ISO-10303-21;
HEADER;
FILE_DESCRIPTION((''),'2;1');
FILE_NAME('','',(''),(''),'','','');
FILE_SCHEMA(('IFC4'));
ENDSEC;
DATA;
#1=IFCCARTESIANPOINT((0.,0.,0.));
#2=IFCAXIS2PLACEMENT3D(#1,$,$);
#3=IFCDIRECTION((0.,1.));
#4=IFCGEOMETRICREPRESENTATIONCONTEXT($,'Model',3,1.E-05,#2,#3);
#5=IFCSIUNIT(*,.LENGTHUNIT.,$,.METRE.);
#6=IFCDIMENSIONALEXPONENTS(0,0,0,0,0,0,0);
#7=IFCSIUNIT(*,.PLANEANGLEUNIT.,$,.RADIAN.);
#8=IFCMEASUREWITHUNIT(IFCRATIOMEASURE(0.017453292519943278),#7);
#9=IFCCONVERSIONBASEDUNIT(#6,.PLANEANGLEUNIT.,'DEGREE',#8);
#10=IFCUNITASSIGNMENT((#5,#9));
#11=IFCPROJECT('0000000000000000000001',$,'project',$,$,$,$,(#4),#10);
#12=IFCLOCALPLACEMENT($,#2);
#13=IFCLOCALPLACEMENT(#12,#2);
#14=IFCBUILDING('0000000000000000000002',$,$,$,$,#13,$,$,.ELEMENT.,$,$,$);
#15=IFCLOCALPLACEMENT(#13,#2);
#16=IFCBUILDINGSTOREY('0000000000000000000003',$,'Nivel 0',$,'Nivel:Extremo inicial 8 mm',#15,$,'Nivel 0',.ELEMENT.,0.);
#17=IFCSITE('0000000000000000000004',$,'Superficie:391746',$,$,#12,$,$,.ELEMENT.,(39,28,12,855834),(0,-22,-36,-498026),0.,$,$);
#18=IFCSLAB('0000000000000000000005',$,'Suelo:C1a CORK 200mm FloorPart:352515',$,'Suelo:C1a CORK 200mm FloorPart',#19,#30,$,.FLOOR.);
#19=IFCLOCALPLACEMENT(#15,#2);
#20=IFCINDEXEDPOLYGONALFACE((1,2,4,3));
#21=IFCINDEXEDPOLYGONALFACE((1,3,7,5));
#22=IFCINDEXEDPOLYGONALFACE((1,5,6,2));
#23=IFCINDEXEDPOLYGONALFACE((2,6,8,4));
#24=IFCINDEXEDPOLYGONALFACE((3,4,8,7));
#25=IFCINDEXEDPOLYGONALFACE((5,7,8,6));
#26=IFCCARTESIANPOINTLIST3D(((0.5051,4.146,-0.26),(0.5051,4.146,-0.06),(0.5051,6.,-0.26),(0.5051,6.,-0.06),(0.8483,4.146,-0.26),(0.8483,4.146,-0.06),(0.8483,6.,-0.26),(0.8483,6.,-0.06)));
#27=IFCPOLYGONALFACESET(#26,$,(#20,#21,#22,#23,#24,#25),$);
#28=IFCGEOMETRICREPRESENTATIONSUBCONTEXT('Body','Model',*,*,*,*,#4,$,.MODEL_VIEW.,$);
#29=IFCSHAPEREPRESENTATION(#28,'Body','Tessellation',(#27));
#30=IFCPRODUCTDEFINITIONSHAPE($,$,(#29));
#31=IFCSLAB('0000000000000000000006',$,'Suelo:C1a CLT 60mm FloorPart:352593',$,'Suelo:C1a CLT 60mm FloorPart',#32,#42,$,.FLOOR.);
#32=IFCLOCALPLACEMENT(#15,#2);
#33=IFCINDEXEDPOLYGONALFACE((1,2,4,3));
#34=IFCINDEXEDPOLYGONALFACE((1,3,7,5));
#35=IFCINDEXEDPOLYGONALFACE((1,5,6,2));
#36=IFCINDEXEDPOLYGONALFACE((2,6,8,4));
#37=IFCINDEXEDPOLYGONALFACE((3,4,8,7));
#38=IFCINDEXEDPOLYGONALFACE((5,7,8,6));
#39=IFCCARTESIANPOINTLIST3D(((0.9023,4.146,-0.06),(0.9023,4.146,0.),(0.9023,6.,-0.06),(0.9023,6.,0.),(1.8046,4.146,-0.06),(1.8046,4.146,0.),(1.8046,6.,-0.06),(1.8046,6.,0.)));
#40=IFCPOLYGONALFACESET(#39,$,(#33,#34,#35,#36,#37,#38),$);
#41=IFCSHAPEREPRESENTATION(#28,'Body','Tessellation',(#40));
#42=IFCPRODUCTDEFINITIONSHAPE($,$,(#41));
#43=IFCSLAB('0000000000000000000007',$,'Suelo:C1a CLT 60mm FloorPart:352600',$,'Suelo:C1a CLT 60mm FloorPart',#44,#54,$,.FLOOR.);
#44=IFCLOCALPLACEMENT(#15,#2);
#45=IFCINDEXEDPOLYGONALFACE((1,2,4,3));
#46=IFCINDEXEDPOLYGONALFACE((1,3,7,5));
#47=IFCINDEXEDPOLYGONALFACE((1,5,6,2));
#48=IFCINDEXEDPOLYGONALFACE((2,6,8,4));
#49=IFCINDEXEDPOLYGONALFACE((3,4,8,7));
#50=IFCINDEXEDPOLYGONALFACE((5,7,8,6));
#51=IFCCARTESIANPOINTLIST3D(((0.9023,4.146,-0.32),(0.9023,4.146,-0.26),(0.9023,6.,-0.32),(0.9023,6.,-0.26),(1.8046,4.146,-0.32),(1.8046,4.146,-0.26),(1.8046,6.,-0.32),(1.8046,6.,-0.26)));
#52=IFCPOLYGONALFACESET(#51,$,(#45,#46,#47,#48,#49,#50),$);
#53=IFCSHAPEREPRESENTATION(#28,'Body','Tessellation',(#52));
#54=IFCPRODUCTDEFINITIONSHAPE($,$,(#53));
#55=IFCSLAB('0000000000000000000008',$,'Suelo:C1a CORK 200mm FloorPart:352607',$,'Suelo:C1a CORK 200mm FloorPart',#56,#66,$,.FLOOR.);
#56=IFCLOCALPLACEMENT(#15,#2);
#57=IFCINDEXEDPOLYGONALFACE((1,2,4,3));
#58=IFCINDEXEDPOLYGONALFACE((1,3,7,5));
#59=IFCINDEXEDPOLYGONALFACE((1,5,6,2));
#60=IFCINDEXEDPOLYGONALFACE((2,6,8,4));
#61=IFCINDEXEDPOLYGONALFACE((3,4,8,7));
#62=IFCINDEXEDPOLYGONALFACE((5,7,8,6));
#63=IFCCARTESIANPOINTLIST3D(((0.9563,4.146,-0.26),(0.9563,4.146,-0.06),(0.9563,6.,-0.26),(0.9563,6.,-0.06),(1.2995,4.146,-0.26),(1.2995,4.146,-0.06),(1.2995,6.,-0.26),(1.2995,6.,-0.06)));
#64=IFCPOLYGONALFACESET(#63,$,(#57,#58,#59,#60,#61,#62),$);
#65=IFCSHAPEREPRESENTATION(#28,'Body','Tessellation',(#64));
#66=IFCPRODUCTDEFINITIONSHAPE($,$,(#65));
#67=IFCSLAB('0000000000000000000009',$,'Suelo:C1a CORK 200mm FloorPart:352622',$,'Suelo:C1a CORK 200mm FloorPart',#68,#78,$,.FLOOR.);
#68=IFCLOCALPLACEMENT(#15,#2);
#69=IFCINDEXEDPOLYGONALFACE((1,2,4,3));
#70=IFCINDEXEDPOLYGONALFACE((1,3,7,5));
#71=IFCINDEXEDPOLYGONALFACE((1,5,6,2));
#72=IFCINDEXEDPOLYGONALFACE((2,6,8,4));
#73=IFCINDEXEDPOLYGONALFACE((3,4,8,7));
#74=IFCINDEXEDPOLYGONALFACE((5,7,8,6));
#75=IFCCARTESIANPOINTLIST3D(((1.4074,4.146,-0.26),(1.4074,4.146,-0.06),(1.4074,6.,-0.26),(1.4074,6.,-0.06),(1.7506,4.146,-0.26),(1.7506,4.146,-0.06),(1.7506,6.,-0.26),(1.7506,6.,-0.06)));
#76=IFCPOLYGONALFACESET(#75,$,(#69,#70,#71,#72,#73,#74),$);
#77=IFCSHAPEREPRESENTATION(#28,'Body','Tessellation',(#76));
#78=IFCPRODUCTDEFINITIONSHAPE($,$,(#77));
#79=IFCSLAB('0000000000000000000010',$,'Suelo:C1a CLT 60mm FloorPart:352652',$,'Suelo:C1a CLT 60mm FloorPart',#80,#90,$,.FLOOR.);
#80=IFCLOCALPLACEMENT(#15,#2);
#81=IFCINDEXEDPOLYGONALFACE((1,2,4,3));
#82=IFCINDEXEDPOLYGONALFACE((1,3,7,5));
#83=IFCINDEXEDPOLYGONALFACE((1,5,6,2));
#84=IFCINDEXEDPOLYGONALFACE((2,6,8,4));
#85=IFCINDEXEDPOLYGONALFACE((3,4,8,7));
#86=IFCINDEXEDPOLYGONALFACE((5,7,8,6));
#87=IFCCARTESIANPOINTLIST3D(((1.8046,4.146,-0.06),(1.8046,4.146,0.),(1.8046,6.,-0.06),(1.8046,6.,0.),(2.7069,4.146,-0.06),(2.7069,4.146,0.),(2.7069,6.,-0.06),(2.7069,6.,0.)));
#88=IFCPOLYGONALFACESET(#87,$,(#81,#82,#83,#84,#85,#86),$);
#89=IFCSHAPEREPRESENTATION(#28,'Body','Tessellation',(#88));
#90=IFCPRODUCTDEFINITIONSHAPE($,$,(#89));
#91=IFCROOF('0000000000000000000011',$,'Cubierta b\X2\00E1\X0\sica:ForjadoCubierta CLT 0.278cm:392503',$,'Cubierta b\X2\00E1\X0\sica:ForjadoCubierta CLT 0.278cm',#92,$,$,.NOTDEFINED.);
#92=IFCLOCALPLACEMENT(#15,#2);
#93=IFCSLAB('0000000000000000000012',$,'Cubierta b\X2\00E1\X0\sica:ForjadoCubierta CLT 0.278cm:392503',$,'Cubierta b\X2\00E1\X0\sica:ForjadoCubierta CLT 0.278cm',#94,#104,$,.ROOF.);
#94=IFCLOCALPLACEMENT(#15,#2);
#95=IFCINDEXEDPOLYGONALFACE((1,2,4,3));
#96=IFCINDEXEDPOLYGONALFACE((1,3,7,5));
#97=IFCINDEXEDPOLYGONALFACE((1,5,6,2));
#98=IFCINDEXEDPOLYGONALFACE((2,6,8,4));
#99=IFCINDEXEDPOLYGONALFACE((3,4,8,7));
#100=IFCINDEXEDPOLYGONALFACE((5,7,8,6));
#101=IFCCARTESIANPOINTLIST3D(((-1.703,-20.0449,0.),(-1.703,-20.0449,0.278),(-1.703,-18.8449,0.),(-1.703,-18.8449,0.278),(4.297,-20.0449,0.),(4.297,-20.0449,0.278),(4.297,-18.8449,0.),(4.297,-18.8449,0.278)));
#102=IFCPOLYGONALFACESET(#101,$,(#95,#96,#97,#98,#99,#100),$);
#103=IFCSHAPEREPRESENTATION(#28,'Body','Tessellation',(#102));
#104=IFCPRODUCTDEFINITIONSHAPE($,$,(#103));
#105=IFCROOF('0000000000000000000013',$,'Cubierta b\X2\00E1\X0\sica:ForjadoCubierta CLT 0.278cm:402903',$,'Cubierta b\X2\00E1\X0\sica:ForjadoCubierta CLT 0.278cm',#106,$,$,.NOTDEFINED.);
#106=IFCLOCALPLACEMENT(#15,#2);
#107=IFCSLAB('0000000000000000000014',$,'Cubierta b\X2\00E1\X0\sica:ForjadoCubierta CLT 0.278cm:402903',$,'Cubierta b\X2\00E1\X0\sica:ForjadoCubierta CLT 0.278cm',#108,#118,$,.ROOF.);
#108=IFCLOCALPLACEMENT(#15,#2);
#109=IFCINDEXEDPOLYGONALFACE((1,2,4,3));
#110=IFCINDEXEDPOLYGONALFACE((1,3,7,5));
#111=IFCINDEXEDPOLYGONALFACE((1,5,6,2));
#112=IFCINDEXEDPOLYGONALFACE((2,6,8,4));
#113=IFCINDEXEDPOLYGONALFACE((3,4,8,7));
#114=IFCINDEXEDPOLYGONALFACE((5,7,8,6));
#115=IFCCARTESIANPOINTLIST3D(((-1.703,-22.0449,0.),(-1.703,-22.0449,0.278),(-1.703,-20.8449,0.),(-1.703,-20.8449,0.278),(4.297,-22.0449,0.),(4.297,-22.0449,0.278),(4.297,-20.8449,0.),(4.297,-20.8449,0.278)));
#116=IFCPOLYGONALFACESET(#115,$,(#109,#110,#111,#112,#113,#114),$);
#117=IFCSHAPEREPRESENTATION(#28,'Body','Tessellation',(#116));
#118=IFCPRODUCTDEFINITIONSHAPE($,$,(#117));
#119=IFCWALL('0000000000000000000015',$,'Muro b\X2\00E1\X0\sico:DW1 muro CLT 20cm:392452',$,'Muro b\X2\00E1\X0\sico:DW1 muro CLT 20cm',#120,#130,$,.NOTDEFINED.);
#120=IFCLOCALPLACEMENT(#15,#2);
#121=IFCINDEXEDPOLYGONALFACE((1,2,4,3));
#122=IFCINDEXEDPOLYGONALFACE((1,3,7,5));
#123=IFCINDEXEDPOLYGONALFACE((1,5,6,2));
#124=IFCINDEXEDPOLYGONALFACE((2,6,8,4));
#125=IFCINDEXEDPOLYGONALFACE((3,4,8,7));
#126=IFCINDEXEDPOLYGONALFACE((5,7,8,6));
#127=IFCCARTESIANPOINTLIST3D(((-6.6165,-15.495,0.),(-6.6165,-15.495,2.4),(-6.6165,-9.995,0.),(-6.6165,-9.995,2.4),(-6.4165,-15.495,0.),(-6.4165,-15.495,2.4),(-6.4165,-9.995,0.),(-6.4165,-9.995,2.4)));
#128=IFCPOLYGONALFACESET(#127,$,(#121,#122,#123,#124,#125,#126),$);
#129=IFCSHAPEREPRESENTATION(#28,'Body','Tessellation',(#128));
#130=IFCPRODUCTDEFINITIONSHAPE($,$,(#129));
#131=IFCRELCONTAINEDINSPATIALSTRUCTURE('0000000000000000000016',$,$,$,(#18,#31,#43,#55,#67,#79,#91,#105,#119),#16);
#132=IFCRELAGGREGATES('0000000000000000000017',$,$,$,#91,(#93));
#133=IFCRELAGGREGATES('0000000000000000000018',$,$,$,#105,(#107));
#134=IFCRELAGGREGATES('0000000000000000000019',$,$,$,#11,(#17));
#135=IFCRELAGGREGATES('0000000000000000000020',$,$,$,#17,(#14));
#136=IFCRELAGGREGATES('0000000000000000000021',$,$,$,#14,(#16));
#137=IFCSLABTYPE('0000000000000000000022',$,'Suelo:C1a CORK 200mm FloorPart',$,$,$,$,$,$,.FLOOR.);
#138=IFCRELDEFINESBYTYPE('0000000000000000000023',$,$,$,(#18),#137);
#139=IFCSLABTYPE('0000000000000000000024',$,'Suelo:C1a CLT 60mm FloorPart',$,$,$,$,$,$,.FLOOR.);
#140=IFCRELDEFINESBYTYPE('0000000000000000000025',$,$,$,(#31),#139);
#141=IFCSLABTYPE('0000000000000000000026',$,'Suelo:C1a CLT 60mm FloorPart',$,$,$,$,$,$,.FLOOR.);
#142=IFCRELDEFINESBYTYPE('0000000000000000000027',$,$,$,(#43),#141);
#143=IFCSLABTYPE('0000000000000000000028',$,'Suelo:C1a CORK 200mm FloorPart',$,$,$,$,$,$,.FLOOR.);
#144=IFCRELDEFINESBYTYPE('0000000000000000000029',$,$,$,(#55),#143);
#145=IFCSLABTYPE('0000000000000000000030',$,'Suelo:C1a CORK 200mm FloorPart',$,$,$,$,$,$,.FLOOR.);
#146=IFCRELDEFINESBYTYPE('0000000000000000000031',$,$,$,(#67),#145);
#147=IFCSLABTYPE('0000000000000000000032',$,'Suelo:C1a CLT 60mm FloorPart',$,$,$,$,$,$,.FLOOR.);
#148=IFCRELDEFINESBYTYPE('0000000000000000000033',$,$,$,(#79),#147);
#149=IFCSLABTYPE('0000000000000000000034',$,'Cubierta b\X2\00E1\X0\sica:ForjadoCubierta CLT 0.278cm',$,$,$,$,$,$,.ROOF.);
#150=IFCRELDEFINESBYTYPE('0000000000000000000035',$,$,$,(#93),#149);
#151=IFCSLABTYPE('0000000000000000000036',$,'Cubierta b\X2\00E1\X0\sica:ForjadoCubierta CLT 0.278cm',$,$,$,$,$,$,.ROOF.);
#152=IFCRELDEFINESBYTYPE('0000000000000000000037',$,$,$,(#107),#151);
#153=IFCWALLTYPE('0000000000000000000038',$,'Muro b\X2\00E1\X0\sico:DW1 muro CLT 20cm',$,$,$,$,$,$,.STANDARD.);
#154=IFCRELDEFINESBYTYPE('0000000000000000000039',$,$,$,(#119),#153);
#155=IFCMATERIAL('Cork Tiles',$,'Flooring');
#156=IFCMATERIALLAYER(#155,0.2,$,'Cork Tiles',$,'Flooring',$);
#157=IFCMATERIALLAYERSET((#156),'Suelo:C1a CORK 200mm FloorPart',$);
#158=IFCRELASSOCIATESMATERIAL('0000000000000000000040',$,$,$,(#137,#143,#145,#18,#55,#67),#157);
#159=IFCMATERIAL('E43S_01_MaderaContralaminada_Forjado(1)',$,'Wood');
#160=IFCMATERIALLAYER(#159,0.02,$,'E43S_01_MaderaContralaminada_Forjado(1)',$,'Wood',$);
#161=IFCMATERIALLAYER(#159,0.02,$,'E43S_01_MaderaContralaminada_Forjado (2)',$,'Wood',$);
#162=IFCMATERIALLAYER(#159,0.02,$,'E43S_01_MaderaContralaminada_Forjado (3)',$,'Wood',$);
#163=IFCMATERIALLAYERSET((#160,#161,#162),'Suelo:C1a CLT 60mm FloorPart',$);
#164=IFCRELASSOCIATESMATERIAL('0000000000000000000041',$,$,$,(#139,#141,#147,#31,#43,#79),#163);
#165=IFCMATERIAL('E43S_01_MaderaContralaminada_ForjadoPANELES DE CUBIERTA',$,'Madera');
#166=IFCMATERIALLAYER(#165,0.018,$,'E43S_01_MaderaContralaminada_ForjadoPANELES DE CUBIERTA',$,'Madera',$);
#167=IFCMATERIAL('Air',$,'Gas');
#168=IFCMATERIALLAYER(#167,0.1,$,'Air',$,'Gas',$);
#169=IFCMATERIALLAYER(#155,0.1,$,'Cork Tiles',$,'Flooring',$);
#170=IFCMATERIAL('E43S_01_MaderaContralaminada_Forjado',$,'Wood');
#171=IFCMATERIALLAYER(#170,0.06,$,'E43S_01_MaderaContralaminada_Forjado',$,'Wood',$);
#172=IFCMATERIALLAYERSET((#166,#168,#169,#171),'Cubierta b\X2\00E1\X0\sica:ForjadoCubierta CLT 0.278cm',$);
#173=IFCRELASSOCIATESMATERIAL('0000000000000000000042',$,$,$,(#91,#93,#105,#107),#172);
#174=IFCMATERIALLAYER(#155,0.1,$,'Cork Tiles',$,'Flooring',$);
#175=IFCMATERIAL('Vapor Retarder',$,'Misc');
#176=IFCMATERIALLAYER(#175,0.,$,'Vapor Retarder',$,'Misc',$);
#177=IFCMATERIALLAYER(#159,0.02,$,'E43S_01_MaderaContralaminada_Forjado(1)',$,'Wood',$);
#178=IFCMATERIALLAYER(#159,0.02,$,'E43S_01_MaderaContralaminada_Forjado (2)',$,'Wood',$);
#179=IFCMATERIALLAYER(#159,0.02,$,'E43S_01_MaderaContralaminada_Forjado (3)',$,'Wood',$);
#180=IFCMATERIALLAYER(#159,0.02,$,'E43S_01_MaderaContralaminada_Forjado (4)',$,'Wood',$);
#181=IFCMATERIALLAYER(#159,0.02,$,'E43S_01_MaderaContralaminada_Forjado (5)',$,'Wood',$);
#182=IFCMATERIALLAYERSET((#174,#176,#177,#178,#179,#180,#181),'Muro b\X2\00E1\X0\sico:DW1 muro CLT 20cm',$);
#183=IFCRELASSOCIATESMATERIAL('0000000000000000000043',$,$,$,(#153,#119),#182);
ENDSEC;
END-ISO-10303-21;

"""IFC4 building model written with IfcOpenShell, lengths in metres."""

from ifc_helpers import new_model, entity, si_unit, converted_unit, direction, frame, frame_2d, origin, origin_2d_with_axis, place, context, subcontext, project, spatial, rectangle, extrude, material, layer, layer_set, layer_usage, type_object, element, aggregate, save


model = new_model("IFC4")

# Units and contexts
model_context = context("Model", 3, precision=1e-05, world=origin(), true_north=direction((0.0, 1.0)))
body_context = subcontext(model_context, "Body", "Model", "MODEL_VIEW")
ifc_project = project(units=[si_unit("LENGTHUNIT", "METRE"), converted_unit("PLANEANGLEUNIT", "DEGREE", entity("IfcRatioMeasure", 0.017453292519943278), si_unit("PLANEANGLEUNIT", "RADIAN"), dimensions=[0, 0, 0, 0, 0, 0, 0])], contexts=[model_context])

# Site, building, storey
site_placement = place(None, origin())
site = spatial("IfcSite", under=ifc_project, at=site_placement, Name="Superficie:391746", CompositionType="ELEMENT", RefLatitude=(39, 28, 12, 855834), RefLongitude=(0, -22, -36, -498026), RefElevation=0.0)
building_placement = place(site_placement, origin())
building = spatial("IfcBuilding", under=site, at=building_placement, CompositionType="ELEMENT")
storey_placement = place(building_placement, origin())
storey = spatial("IfcBuildingStorey", under=building, at=storey_placement, Name="Nivel 0", ObjectType="Nivel:Extremo inicial 8 mm", LongName="Nivel 0", CompositionType="ELEMENT", Elevation=0.0)

# Shared definitions
ifc_material_1 = material(Name="E43S_01_MaderaContralaminada_Forjado(1)", Category="Wood")

# Slabs
ifc_layer_1 = layer(ifc_material_1, 0.02, Name="E43S_01_MaderaContralaminada_Forjado(1)", Category="Wood")
ifc_layer_2 = layer(ifc_material_1, 0.02, Name="E43S_01_MaderaContralaminada_Forjado (2)", Category="Wood")
ifc_layer_3 = layer(ifc_material_1, 0.02, Name="E43S_01_MaderaContralaminada_Forjado (3)", Category="Wood")
ifc_layer_set_1 = layer_set([ifc_layer_1, ifc_layer_2, ifc_layer_3], Name="Suelo:C1a CLT 60mm FloorPart")
ifc_material_2 = material(Name="Cork Tiles", Category="Flooring")
ifc_layer_4 = layer(ifc_material_2, 0.2, Name="Cork Tiles", Category="Flooring")
ifc_layer_set_2 = layer_set([ifc_layer_4], Name="Suelo:C1a CORK 200mm FloorPart")
ifc_layer_usage_1 = layer_usage(ifc_layer_set_2, "AXIS3", "POSITIVE", 0.0)
slab_type_1 = type_object("IfcSlabType", Name="Suelo:C1a CORK 200mm FloorPart", PredefinedType="FLOOR", material=ifc_layer_set_2)
slab_1_placement = place(storey_placement, origin())
element("IfcSlab", 1, at=slab_1_placement, inside=storey, type_object=slab_type_1, material=ifc_layer_usage_1, Name="Suelo:C1a CORK 200mm FloorPart:352515", ObjectType="Suelo:C1a CORK 200mm FloorPart", PredefinedType="FLOOR", context=body_context, shape_type="SweptSolid", body=[
    extrude(rectangle(XDim=1.854, YDim=0.3432, at=frame_2d((0.0, 0.0), x_axis=(1.0, 0.0))), frame((0.6767, 5.073, -0.06), z_axis=(0.0, 0.0, -1.0), x_axis=(0.0, 1.0, 0.0)), (0.0, 0.0, 1.0), 0.2),
])
ifc_layer_usage_2 = layer_usage(ifc_layer_set_1, "AXIS3", "POSITIVE", 0.0)
slab_type_2 = type_object("IfcSlabType", Name="Suelo:C1a CLT 60mm FloorPart", PredefinedType="FLOOR", material=ifc_layer_set_1)
slab_2_placement = place(storey_placement, origin())
element("IfcSlab", 2, at=slab_2_placement, inside=storey, type_object=slab_type_2, material=ifc_layer_usage_2, Name="Suelo:C1a CLT 60mm FloorPart:352593", ObjectType="Suelo:C1a CLT 60mm FloorPart", PredefinedType="FLOOR", context=body_context, shape_type="SweptSolid", body=[
    extrude(rectangle(XDim=1.854, YDim=0.9023, at=frame_2d((0.0, 0.0), x_axis=(1.0, 0.0))), frame((1.3535, 5.073, 0.0), z_axis=(0.0, 0.0, -1.0), x_axis=(0.0, 1.0, 0.0)), (0.0, 0.0, 1.0), 0.06),
])
ifc_layer_usage_3 = layer_usage(ifc_layer_set_1, "AXIS3", "POSITIVE", 0.0)
slab_type_3 = type_object("IfcSlabType", Name="Suelo:C1a CLT 60mm FloorPart", PredefinedType="FLOOR", material=ifc_layer_set_1)
slab_3_placement = place(storey_placement, origin())
element("IfcSlab", 3, at=slab_3_placement, inside=storey, type_object=slab_type_3, material=ifc_layer_usage_3, Name="Suelo:C1a CLT 60mm FloorPart:352600", ObjectType="Suelo:C1a CLT 60mm FloorPart", PredefinedType="FLOOR", context=body_context, shape_type="SweptSolid", body=[
    extrude(rectangle(XDim=1.854, YDim=0.9023, at=frame_2d((0.0, 0.0), x_axis=(1.0, 0.0))), frame((1.3535, 5.073, -0.26), z_axis=(0.0, 0.0, -1.0), x_axis=(0.0, 1.0, 0.0)), (0.0, 0.0, 1.0), 0.06),
])
ifc_layer_usage_4 = layer_usage(ifc_layer_set_2, "AXIS3", "POSITIVE", 0.0)
slab_type_4 = type_object("IfcSlabType", Name="Suelo:C1a CORK 200mm FloorPart", PredefinedType="FLOOR", material=ifc_layer_set_2)
slab_4_placement = place(storey_placement, origin())
element("IfcSlab", 4, at=slab_4_placement, inside=storey, type_object=slab_type_4, material=ifc_layer_usage_4, Name="Suelo:C1a CORK 200mm FloorPart:352607", ObjectType="Suelo:C1a CORK 200mm FloorPart", PredefinedType="FLOOR", context=body_context, shape_type="SweptSolid", body=[
    extrude(rectangle(XDim=1.854, YDim=0.3432, at=frame_2d((0.0, 0.0), x_axis=(1.0, 0.0))), frame((1.1279, 5.073, -0.06), z_axis=(0.0, 0.0, -1.0), x_axis=(0.0, 1.0, 0.0)), (0.0, 0.0, 1.0), 0.2),
])
ifc_layer_usage_5 = layer_usage(ifc_layer_set_2, "AXIS3", "POSITIVE", 0.0)
slab_type_5 = type_object("IfcSlabType", Name="Suelo:C1a CORK 200mm FloorPart", PredefinedType="FLOOR", material=ifc_layer_set_2)
slab_5_placement = place(storey_placement, origin())
element("IfcSlab", 5, at=slab_5_placement, inside=storey, type_object=slab_type_5, material=ifc_layer_usage_5, Name="Suelo:C1a CORK 200mm FloorPart:352622", ObjectType="Suelo:C1a CORK 200mm FloorPart", PredefinedType="FLOOR", context=body_context, shape_type="SweptSolid", body=[
    extrude(rectangle(XDim=1.854, YDim=0.3432, at=frame_2d((0.0, 0.0), x_axis=(1.0, 0.0))), frame((1.579, 5.073, -0.06), z_axis=(0.0, 0.0, -1.0), x_axis=(0.0, 1.0, 0.0)), (0.0, 0.0, 1.0), 0.2),
])
ifc_layer_usage_6 = layer_usage(ifc_layer_set_1, "AXIS3", "POSITIVE", 0.0)
slab_type_6 = type_object("IfcSlabType", Name="Suelo:C1a CLT 60mm FloorPart", PredefinedType="FLOOR", material=ifc_layer_set_1)
slab_6_placement = place(storey_placement, origin())
element("IfcSlab", 6, at=slab_6_placement, inside=storey, type_object=slab_type_6, material=ifc_layer_usage_6, Name="Suelo:C1a CLT 60mm FloorPart:352652", ObjectType="Suelo:C1a CLT 60mm FloorPart", PredefinedType="FLOOR", context=body_context, shape_type="SweptSolid", body=[
    extrude(rectangle(XDim=1.854, YDim=0.9023, at=frame_2d((0.0, 0.0), x_axis=(1.0, 0.0))), frame((2.2558, 5.073, 0.0), z_axis=(0.0, 0.0, -1.0), x_axis=(0.0, 1.0, 0.0)), (0.0, 0.0, 1.0), 0.06),
])

# Roofs, slabs
ifc_material_3 = material(Name="E43S_01_MaderaContralaminada_ForjadoPANELES DE CUBIERTA", Category="Madera")
ifc_layer_5 = layer(ifc_material_3, 0.018, Name="E43S_01_MaderaContralaminada_ForjadoPANELES DE CUBIERTA", Category="Madera")
ifc_material_4 = material(Name="Air", Category="Gas")
ifc_layer_6 = layer(ifc_material_4, 0.1, Name="Air", Category="Gas")
ifc_layer_7 = layer(ifc_material_2, 0.1, Name="Cork Tiles", Category="Flooring")
ifc_material_5 = material(Name="E43S_01_MaderaContralaminada_Forjado", Category="Wood")
ifc_layer_8 = layer(ifc_material_5, 0.06, Name="E43S_01_MaderaContralaminada_Forjado", Category="Wood")
ifc_layer_set_3 = layer_set([ifc_layer_5, ifc_layer_6, ifc_layer_7, ifc_layer_8], Name="Cubierta básica:ForjadoCubierta CLT 0.278cm")
roof_1_placement = place(storey_placement, frame((-1.703, -20.0449, 0.0)))
roof_1 = element("IfcRoof", 7, at=roof_1_placement, inside=storey, material=ifc_layer_set_3, Name="Cubierta básica:ForjadoCubierta CLT 0.278cm:392503", ObjectType="Cubierta básica:ForjadoCubierta CLT 0.278cm", PredefinedType="NOTDEFINED")
slab_type_7 = type_object("IfcSlabType", Name="Cubierta básica:ForjadoCubierta CLT 0.278cm", PredefinedType="ROOF")
slab_7_placement = place(roof_1_placement, origin())
slab_7 = element("IfcSlab", 8, at=slab_7_placement, type_object=slab_type_7, material=ifc_layer_set_3, Name="Cubierta básica:ForjadoCubierta CLT 0.278cm:392503", ObjectType="Cubierta básica:ForjadoCubierta CLT 0.278cm", PredefinedType="ROOF", context=body_context, shape_type="SweptSolid", body=[
    extrude(rectangle(XDim=6.0, YDim=1.2, at=frame_2d((0.0, 0.0), x_axis=(1.0, 0.0))), frame((3.0, 0.6, 0.0)), (0.0, 0.0, 1.0), 0.278),
])
aggregate(roof_1, [slab_7])
roof_2_placement = place(storey_placement, frame((-1.703, -22.0449, 0.0)))
roof_2 = element("IfcRoof", 9, at=roof_2_placement, inside=storey, material=ifc_layer_set_3, Name="Cubierta básica:ForjadoCubierta CLT 0.278cm:402903", ObjectType="Cubierta básica:ForjadoCubierta CLT 0.278cm", PredefinedType="NOTDEFINED")
slab_type_8 = type_object("IfcSlabType", Name="Cubierta básica:ForjadoCubierta CLT 0.278cm", PredefinedType="ROOF")
slab_8_placement = place(roof_2_placement, origin())
slab_8 = element("IfcSlab", 10, at=slab_8_placement, type_object=slab_type_8, material=ifc_layer_set_3, Name="Cubierta básica:ForjadoCubierta CLT 0.278cm:402903", ObjectType="Cubierta básica:ForjadoCubierta CLT 0.278cm", PredefinedType="ROOF", context=body_context, shape_type="SweptSolid", body=[
    extrude(rectangle(XDim=6.0, YDim=1.2, at=origin_2d_with_axis()), frame((3.0, 0.6, 0.0)), (0.0, 0.0, 1.0), 0.278),
])
aggregate(roof_2, [slab_8])

# Wall
ifc_layer_9 = layer(ifc_material_2, 0.1, Name="Cork Tiles", Category="Flooring")
ifc_material_6 = material(Name="Vapor Retarder", Category="Misc")
ifc_layer_10 = layer(ifc_material_6, 0.0, Name="Vapor Retarder", Category="Misc")
ifc_layer_11 = layer(ifc_material_1, 0.02, Name="E43S_01_MaderaContralaminada_Forjado(1)", Category="Wood")
ifc_layer_12 = layer(ifc_material_1, 0.02, Name="E43S_01_MaderaContralaminada_Forjado (2)", Category="Wood")
ifc_layer_13 = layer(ifc_material_1, 0.02, Name="E43S_01_MaderaContralaminada_Forjado (3)", Category="Wood")
ifc_layer_14 = layer(ifc_material_1, 0.02, Name="E43S_01_MaderaContralaminada_Forjado (4)", Category="Wood")
ifc_layer_15 = layer(ifc_material_1, 0.02, Name="E43S_01_MaderaContralaminada_Forjado (5)", Category="Wood")
ifc_layer_set_4 = layer_set([ifc_layer_9, ifc_layer_10, ifc_layer_11, ifc_layer_12, ifc_layer_13, ifc_layer_14, ifc_layer_15], Name="Muro básico:DW1 muro CLT 20cm")
ifc_layer_usage_7 = layer_usage(ifc_layer_set_4, "AXIS2", "NEGATIVE", 0.1)
wall_type = type_object("IfcWallType", Name="Muro básico:DW1 muro CLT 20cm", PredefinedType="STANDARD", material=ifc_layer_set_4)
wall_placement = place(storey_placement, frame((-6.5165, -15.495, 0.0), z_axis=(0.0, 0.0, 1.0), x_axis=(0.0, 1.0, 0.0)))
element("IfcWall", 11, at=wall_placement, inside=storey, type_object=wall_type, material=ifc_layer_usage_7, Name="Muro básico:DW1 muro CLT 20cm:392452", ObjectType="Muro básico:DW1 muro CLT 20cm", PredefinedType="NOTDEFINED", context=body_context, shape_type="SweptSolid", body=[
    extrude(rectangle(XDim=5.5, YDim=0.2, at=frame_2d((2.75, 0.0), x_axis=(-1.0, 0.0))), origin(), (0.0, 0.0, 1.0), 2.4),
])

save(model, "model.ifc")
